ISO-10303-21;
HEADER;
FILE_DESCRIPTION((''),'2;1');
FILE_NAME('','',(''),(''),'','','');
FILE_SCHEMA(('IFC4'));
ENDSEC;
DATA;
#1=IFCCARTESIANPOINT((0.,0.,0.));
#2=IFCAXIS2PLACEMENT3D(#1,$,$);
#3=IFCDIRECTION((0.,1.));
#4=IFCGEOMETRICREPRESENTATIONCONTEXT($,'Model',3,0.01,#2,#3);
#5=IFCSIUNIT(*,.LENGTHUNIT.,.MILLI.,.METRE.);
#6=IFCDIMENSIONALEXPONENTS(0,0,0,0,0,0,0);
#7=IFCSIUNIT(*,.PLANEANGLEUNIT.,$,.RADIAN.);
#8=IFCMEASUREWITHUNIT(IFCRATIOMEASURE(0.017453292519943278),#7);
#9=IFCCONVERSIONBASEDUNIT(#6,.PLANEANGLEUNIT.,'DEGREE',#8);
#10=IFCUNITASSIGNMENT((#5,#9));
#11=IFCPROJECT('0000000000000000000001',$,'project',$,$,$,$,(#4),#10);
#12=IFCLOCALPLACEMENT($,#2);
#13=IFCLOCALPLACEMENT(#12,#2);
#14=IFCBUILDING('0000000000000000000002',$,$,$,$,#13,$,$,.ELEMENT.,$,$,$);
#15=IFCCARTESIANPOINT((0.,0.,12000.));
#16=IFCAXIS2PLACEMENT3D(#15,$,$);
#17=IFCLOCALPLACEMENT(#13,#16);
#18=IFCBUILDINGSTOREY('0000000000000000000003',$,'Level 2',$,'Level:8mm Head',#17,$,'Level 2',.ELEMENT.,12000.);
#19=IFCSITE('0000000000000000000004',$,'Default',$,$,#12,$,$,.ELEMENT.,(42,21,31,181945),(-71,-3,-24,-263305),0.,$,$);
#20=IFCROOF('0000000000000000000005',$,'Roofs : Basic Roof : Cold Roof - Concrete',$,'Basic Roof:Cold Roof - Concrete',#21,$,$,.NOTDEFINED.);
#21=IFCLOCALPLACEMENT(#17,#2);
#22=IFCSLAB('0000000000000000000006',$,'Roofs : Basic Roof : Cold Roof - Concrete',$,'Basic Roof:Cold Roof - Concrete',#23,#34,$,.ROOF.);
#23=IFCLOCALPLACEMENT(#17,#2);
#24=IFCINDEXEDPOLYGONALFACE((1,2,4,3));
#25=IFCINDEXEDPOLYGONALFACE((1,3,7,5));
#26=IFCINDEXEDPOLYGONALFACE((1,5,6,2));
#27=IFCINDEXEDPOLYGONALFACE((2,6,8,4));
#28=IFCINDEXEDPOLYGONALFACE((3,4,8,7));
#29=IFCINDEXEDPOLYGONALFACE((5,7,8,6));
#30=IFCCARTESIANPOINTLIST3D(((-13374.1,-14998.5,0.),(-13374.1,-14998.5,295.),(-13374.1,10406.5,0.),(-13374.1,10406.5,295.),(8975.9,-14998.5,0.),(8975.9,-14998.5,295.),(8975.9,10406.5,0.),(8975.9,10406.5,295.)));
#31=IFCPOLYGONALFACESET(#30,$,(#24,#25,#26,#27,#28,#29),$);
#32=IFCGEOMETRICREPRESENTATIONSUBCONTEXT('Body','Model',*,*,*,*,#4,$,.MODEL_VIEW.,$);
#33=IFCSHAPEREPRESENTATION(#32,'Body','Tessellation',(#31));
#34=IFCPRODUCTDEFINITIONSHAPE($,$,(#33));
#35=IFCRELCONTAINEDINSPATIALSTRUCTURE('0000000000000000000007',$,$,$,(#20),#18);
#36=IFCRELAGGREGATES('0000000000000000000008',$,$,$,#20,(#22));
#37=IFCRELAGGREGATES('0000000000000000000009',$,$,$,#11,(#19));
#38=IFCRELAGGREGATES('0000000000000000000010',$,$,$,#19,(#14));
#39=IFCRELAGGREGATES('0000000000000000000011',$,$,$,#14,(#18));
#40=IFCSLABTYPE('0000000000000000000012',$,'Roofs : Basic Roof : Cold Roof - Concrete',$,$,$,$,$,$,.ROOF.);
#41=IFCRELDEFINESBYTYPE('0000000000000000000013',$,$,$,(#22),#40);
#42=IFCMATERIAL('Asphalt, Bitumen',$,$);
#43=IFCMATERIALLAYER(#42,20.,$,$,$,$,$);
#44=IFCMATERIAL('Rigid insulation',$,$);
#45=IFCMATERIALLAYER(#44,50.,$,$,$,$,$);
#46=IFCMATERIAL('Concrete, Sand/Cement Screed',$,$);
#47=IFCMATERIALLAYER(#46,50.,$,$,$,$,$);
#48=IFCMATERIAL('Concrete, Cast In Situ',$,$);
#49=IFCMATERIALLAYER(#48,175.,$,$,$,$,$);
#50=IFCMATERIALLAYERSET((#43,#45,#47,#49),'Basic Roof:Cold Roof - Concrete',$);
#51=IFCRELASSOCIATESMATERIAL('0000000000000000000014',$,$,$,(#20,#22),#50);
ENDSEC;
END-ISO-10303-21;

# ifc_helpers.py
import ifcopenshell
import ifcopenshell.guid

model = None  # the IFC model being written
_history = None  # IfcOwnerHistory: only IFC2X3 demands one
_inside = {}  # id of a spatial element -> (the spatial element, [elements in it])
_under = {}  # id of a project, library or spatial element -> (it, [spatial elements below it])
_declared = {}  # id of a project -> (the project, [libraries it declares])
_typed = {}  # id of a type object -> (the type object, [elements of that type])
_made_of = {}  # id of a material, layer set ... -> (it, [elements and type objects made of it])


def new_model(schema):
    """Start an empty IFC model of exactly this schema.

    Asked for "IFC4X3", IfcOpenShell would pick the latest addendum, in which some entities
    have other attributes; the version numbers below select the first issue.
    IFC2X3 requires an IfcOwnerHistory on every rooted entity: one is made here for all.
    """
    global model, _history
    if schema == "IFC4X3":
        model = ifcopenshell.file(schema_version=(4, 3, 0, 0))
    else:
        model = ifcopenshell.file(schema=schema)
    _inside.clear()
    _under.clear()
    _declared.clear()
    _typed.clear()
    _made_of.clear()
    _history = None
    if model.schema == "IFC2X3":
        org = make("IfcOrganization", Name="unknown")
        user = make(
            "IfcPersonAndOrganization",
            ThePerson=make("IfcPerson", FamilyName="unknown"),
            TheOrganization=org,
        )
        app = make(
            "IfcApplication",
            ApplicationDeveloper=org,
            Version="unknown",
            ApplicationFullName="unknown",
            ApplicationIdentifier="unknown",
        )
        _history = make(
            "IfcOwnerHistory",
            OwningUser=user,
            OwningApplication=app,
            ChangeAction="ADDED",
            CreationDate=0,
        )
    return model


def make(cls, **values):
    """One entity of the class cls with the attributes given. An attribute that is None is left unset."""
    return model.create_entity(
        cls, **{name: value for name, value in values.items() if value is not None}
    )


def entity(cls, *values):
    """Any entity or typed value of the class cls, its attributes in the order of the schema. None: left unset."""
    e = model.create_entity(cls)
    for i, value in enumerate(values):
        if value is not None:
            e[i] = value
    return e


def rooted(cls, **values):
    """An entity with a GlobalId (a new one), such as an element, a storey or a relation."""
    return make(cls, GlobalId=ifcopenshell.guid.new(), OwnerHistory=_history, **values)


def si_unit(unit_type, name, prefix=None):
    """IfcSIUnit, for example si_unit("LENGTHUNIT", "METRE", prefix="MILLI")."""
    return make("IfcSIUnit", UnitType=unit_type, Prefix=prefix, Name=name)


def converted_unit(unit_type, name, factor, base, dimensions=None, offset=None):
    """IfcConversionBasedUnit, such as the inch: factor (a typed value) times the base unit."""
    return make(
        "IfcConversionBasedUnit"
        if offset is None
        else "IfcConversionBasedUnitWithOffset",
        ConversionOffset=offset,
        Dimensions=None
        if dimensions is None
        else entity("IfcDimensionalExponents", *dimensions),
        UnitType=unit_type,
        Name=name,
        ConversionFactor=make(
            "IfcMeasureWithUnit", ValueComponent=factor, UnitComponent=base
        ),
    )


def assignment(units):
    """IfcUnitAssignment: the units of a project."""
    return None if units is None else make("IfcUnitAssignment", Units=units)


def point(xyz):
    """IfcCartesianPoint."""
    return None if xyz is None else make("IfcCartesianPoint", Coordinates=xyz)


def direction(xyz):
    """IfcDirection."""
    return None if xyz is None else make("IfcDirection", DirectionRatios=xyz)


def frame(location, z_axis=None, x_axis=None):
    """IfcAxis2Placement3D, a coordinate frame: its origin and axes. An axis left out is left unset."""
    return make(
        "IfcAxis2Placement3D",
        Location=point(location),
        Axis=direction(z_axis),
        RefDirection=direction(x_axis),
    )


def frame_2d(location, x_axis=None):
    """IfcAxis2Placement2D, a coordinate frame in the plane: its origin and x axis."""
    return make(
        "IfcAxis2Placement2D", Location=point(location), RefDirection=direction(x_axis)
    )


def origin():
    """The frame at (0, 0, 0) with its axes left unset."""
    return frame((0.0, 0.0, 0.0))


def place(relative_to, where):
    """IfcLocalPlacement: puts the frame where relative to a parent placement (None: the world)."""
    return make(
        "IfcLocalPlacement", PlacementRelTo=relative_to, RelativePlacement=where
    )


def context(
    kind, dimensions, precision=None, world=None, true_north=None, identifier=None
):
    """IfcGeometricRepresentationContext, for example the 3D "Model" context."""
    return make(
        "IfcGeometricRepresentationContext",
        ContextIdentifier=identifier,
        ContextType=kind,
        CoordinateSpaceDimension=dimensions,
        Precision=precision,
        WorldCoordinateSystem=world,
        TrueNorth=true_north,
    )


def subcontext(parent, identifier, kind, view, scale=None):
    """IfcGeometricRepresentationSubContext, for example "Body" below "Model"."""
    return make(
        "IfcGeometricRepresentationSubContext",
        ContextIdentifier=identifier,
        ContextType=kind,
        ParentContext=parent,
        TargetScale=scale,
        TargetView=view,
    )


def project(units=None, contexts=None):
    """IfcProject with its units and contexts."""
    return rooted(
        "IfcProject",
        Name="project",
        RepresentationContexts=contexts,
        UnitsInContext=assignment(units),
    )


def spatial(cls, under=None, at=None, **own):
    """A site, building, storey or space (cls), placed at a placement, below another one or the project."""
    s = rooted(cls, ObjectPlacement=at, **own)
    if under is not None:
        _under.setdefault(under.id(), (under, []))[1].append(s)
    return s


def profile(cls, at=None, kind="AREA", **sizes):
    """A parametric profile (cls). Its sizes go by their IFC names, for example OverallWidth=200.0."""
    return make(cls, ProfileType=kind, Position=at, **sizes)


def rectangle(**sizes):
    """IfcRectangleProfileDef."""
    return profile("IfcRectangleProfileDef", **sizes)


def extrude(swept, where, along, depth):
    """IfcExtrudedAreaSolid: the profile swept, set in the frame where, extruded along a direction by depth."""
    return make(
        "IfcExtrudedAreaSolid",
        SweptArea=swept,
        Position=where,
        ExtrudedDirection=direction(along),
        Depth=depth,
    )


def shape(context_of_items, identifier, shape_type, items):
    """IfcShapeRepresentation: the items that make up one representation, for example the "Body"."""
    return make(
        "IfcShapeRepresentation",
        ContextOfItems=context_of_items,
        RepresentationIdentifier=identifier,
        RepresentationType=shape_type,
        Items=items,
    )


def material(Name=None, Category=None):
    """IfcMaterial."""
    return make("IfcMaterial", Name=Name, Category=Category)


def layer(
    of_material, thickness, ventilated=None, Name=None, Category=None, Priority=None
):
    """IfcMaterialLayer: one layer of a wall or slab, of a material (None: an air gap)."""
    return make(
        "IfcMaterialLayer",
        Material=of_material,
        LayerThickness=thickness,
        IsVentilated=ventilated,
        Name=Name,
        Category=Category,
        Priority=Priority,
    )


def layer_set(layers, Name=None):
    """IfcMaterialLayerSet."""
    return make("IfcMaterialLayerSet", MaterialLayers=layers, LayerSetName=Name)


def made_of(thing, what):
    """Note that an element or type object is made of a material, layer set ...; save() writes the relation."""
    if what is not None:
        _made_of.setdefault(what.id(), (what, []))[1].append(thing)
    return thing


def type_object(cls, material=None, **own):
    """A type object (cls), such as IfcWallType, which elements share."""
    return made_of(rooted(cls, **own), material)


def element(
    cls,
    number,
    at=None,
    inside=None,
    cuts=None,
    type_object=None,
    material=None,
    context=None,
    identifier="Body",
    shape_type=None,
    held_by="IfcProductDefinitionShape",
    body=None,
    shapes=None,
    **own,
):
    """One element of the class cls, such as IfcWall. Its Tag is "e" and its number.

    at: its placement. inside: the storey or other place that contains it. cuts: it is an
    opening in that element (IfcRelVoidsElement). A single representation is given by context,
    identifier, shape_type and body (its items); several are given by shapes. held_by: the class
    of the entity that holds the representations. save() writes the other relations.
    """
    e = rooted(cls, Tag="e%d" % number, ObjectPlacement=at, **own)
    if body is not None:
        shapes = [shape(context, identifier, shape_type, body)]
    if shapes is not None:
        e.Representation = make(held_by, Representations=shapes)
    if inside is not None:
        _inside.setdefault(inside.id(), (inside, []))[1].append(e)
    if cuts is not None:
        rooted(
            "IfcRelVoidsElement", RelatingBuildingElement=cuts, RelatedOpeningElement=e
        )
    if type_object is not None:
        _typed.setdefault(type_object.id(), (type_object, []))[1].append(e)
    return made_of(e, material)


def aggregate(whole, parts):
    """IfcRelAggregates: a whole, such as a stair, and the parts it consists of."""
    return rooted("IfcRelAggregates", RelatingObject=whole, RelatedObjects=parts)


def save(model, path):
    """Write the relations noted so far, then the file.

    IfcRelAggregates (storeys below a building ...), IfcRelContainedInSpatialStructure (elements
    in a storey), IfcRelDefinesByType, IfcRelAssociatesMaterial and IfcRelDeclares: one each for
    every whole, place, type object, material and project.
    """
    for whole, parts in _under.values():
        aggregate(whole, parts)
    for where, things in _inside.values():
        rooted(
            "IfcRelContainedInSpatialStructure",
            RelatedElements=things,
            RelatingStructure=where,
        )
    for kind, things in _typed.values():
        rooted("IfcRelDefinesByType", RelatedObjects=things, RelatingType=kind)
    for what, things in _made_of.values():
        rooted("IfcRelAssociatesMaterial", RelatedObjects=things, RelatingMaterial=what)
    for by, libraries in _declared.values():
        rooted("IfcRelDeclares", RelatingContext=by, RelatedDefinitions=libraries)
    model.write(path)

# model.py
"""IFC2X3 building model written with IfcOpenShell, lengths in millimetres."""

from ifc_helpers import new_model, entity, si_unit, converted_unit, direction, frame, frame_2d, origin, place, context, subcontext, project, spatial, rectangle, extrude, material, layer, layer_set, type_object, element, aggregate, save


model = new_model("IFC2X3")

# Units and contexts
model_context = context("Model", 3, precision=0.01, world=origin(), true_north=direction((0.0, 1.0)))
body_context = subcontext(model_context, "Body", "Model", "MODEL_VIEW")
ifc_project = project(units=[si_unit("LENGTHUNIT", "METRE", prefix="MILLI"), converted_unit("PLANEANGLEUNIT", "DEGREE", entity("IfcRatioMeasure", 0.017453292519943278), si_unit("PLANEANGLEUNIT", "RADIAN"), dimensions=[0, 0, 0, 0, 0, 0, 0])], contexts=[model_context])

# Site, building, storey
site_placement = place(None, origin())
site = spatial("IfcSite", under=ifc_project, at=site_placement, Name="Default", CompositionType="ELEMENT", RefLatitude=(42, 21, 31, 181945), RefLongitude=(-71, -3, -24, -263305), RefElevation=0.0)
building_placement = place(site_placement, origin())
building = spatial("IfcBuilding", under=site, at=building_placement, CompositionType="ELEMENT")
storey_placement = place(building_placement, frame((0.0, 0.0, 12000.0)))
storey = spatial("IfcBuildingStorey", under=building, at=storey_placement, Name="Level 2", ObjectType="Level:8mm Head", LongName="Level 2", CompositionType="ELEMENT", Elevation=12000.0)

# Roof, slab
ifc_material_1 = material(Name="Asphalt, Bitumen")
ifc_layer_1 = layer(ifc_material_1, 20.0)
ifc_material_2 = material(Name="Rigid insulation")
ifc_layer_2 = layer(ifc_material_2, 50.0)
ifc_material_3 = material(Name="Concrete, Sand/Cement Screed")
ifc_layer_3 = layer(ifc_material_3, 50.0)
ifc_material_4 = material(Name="Concrete, Cast In Situ")
ifc_layer_4 = layer(ifc_material_4, 175.0)
ifc_layer_set = layer_set([ifc_layer_1, ifc_layer_2, ifc_layer_3, ifc_layer_4], Name="Basic Roof:Cold Roof - Concrete")
roof_placement = place(storey_placement, frame((-13374.1, -14998.5, 0.0)))
roof = element("IfcRoof", 1, at=roof_placement, inside=storey, material=ifc_layer_set, Name="Roofs : Basic Roof : Cold Roof - Concrete", ObjectType="Basic Roof:Cold Roof - Concrete", ShapeType="NOTDEFINED")
slab_type = type_object("IfcSlabType", Name="Roofs : Basic Roof : Cold Roof - Concrete", PredefinedType="ROOF")
slab_placement = place(roof_placement, origin())
slab = element("IfcSlab", 2, at=slab_placement, type_object=slab_type, material=ifc_layer_set, Name="Roofs : Basic Roof : Cold Roof - Concrete", ObjectType="Basic Roof:Cold Roof - Concrete", PredefinedType="ROOF", context=body_context, shape_type="SweptSolid", body=[
    extrude(rectangle(XDim=22350.0, YDim=25405.0, at=frame_2d((0.0, 0.0), x_axis=(1.0, 0.0))), frame((11175.0, 12702.5, 0.0)), (0.0, 0.0, 1.0), 295.0),
])
aggregate(roof, [slab])

save(model, "model.ifc")
